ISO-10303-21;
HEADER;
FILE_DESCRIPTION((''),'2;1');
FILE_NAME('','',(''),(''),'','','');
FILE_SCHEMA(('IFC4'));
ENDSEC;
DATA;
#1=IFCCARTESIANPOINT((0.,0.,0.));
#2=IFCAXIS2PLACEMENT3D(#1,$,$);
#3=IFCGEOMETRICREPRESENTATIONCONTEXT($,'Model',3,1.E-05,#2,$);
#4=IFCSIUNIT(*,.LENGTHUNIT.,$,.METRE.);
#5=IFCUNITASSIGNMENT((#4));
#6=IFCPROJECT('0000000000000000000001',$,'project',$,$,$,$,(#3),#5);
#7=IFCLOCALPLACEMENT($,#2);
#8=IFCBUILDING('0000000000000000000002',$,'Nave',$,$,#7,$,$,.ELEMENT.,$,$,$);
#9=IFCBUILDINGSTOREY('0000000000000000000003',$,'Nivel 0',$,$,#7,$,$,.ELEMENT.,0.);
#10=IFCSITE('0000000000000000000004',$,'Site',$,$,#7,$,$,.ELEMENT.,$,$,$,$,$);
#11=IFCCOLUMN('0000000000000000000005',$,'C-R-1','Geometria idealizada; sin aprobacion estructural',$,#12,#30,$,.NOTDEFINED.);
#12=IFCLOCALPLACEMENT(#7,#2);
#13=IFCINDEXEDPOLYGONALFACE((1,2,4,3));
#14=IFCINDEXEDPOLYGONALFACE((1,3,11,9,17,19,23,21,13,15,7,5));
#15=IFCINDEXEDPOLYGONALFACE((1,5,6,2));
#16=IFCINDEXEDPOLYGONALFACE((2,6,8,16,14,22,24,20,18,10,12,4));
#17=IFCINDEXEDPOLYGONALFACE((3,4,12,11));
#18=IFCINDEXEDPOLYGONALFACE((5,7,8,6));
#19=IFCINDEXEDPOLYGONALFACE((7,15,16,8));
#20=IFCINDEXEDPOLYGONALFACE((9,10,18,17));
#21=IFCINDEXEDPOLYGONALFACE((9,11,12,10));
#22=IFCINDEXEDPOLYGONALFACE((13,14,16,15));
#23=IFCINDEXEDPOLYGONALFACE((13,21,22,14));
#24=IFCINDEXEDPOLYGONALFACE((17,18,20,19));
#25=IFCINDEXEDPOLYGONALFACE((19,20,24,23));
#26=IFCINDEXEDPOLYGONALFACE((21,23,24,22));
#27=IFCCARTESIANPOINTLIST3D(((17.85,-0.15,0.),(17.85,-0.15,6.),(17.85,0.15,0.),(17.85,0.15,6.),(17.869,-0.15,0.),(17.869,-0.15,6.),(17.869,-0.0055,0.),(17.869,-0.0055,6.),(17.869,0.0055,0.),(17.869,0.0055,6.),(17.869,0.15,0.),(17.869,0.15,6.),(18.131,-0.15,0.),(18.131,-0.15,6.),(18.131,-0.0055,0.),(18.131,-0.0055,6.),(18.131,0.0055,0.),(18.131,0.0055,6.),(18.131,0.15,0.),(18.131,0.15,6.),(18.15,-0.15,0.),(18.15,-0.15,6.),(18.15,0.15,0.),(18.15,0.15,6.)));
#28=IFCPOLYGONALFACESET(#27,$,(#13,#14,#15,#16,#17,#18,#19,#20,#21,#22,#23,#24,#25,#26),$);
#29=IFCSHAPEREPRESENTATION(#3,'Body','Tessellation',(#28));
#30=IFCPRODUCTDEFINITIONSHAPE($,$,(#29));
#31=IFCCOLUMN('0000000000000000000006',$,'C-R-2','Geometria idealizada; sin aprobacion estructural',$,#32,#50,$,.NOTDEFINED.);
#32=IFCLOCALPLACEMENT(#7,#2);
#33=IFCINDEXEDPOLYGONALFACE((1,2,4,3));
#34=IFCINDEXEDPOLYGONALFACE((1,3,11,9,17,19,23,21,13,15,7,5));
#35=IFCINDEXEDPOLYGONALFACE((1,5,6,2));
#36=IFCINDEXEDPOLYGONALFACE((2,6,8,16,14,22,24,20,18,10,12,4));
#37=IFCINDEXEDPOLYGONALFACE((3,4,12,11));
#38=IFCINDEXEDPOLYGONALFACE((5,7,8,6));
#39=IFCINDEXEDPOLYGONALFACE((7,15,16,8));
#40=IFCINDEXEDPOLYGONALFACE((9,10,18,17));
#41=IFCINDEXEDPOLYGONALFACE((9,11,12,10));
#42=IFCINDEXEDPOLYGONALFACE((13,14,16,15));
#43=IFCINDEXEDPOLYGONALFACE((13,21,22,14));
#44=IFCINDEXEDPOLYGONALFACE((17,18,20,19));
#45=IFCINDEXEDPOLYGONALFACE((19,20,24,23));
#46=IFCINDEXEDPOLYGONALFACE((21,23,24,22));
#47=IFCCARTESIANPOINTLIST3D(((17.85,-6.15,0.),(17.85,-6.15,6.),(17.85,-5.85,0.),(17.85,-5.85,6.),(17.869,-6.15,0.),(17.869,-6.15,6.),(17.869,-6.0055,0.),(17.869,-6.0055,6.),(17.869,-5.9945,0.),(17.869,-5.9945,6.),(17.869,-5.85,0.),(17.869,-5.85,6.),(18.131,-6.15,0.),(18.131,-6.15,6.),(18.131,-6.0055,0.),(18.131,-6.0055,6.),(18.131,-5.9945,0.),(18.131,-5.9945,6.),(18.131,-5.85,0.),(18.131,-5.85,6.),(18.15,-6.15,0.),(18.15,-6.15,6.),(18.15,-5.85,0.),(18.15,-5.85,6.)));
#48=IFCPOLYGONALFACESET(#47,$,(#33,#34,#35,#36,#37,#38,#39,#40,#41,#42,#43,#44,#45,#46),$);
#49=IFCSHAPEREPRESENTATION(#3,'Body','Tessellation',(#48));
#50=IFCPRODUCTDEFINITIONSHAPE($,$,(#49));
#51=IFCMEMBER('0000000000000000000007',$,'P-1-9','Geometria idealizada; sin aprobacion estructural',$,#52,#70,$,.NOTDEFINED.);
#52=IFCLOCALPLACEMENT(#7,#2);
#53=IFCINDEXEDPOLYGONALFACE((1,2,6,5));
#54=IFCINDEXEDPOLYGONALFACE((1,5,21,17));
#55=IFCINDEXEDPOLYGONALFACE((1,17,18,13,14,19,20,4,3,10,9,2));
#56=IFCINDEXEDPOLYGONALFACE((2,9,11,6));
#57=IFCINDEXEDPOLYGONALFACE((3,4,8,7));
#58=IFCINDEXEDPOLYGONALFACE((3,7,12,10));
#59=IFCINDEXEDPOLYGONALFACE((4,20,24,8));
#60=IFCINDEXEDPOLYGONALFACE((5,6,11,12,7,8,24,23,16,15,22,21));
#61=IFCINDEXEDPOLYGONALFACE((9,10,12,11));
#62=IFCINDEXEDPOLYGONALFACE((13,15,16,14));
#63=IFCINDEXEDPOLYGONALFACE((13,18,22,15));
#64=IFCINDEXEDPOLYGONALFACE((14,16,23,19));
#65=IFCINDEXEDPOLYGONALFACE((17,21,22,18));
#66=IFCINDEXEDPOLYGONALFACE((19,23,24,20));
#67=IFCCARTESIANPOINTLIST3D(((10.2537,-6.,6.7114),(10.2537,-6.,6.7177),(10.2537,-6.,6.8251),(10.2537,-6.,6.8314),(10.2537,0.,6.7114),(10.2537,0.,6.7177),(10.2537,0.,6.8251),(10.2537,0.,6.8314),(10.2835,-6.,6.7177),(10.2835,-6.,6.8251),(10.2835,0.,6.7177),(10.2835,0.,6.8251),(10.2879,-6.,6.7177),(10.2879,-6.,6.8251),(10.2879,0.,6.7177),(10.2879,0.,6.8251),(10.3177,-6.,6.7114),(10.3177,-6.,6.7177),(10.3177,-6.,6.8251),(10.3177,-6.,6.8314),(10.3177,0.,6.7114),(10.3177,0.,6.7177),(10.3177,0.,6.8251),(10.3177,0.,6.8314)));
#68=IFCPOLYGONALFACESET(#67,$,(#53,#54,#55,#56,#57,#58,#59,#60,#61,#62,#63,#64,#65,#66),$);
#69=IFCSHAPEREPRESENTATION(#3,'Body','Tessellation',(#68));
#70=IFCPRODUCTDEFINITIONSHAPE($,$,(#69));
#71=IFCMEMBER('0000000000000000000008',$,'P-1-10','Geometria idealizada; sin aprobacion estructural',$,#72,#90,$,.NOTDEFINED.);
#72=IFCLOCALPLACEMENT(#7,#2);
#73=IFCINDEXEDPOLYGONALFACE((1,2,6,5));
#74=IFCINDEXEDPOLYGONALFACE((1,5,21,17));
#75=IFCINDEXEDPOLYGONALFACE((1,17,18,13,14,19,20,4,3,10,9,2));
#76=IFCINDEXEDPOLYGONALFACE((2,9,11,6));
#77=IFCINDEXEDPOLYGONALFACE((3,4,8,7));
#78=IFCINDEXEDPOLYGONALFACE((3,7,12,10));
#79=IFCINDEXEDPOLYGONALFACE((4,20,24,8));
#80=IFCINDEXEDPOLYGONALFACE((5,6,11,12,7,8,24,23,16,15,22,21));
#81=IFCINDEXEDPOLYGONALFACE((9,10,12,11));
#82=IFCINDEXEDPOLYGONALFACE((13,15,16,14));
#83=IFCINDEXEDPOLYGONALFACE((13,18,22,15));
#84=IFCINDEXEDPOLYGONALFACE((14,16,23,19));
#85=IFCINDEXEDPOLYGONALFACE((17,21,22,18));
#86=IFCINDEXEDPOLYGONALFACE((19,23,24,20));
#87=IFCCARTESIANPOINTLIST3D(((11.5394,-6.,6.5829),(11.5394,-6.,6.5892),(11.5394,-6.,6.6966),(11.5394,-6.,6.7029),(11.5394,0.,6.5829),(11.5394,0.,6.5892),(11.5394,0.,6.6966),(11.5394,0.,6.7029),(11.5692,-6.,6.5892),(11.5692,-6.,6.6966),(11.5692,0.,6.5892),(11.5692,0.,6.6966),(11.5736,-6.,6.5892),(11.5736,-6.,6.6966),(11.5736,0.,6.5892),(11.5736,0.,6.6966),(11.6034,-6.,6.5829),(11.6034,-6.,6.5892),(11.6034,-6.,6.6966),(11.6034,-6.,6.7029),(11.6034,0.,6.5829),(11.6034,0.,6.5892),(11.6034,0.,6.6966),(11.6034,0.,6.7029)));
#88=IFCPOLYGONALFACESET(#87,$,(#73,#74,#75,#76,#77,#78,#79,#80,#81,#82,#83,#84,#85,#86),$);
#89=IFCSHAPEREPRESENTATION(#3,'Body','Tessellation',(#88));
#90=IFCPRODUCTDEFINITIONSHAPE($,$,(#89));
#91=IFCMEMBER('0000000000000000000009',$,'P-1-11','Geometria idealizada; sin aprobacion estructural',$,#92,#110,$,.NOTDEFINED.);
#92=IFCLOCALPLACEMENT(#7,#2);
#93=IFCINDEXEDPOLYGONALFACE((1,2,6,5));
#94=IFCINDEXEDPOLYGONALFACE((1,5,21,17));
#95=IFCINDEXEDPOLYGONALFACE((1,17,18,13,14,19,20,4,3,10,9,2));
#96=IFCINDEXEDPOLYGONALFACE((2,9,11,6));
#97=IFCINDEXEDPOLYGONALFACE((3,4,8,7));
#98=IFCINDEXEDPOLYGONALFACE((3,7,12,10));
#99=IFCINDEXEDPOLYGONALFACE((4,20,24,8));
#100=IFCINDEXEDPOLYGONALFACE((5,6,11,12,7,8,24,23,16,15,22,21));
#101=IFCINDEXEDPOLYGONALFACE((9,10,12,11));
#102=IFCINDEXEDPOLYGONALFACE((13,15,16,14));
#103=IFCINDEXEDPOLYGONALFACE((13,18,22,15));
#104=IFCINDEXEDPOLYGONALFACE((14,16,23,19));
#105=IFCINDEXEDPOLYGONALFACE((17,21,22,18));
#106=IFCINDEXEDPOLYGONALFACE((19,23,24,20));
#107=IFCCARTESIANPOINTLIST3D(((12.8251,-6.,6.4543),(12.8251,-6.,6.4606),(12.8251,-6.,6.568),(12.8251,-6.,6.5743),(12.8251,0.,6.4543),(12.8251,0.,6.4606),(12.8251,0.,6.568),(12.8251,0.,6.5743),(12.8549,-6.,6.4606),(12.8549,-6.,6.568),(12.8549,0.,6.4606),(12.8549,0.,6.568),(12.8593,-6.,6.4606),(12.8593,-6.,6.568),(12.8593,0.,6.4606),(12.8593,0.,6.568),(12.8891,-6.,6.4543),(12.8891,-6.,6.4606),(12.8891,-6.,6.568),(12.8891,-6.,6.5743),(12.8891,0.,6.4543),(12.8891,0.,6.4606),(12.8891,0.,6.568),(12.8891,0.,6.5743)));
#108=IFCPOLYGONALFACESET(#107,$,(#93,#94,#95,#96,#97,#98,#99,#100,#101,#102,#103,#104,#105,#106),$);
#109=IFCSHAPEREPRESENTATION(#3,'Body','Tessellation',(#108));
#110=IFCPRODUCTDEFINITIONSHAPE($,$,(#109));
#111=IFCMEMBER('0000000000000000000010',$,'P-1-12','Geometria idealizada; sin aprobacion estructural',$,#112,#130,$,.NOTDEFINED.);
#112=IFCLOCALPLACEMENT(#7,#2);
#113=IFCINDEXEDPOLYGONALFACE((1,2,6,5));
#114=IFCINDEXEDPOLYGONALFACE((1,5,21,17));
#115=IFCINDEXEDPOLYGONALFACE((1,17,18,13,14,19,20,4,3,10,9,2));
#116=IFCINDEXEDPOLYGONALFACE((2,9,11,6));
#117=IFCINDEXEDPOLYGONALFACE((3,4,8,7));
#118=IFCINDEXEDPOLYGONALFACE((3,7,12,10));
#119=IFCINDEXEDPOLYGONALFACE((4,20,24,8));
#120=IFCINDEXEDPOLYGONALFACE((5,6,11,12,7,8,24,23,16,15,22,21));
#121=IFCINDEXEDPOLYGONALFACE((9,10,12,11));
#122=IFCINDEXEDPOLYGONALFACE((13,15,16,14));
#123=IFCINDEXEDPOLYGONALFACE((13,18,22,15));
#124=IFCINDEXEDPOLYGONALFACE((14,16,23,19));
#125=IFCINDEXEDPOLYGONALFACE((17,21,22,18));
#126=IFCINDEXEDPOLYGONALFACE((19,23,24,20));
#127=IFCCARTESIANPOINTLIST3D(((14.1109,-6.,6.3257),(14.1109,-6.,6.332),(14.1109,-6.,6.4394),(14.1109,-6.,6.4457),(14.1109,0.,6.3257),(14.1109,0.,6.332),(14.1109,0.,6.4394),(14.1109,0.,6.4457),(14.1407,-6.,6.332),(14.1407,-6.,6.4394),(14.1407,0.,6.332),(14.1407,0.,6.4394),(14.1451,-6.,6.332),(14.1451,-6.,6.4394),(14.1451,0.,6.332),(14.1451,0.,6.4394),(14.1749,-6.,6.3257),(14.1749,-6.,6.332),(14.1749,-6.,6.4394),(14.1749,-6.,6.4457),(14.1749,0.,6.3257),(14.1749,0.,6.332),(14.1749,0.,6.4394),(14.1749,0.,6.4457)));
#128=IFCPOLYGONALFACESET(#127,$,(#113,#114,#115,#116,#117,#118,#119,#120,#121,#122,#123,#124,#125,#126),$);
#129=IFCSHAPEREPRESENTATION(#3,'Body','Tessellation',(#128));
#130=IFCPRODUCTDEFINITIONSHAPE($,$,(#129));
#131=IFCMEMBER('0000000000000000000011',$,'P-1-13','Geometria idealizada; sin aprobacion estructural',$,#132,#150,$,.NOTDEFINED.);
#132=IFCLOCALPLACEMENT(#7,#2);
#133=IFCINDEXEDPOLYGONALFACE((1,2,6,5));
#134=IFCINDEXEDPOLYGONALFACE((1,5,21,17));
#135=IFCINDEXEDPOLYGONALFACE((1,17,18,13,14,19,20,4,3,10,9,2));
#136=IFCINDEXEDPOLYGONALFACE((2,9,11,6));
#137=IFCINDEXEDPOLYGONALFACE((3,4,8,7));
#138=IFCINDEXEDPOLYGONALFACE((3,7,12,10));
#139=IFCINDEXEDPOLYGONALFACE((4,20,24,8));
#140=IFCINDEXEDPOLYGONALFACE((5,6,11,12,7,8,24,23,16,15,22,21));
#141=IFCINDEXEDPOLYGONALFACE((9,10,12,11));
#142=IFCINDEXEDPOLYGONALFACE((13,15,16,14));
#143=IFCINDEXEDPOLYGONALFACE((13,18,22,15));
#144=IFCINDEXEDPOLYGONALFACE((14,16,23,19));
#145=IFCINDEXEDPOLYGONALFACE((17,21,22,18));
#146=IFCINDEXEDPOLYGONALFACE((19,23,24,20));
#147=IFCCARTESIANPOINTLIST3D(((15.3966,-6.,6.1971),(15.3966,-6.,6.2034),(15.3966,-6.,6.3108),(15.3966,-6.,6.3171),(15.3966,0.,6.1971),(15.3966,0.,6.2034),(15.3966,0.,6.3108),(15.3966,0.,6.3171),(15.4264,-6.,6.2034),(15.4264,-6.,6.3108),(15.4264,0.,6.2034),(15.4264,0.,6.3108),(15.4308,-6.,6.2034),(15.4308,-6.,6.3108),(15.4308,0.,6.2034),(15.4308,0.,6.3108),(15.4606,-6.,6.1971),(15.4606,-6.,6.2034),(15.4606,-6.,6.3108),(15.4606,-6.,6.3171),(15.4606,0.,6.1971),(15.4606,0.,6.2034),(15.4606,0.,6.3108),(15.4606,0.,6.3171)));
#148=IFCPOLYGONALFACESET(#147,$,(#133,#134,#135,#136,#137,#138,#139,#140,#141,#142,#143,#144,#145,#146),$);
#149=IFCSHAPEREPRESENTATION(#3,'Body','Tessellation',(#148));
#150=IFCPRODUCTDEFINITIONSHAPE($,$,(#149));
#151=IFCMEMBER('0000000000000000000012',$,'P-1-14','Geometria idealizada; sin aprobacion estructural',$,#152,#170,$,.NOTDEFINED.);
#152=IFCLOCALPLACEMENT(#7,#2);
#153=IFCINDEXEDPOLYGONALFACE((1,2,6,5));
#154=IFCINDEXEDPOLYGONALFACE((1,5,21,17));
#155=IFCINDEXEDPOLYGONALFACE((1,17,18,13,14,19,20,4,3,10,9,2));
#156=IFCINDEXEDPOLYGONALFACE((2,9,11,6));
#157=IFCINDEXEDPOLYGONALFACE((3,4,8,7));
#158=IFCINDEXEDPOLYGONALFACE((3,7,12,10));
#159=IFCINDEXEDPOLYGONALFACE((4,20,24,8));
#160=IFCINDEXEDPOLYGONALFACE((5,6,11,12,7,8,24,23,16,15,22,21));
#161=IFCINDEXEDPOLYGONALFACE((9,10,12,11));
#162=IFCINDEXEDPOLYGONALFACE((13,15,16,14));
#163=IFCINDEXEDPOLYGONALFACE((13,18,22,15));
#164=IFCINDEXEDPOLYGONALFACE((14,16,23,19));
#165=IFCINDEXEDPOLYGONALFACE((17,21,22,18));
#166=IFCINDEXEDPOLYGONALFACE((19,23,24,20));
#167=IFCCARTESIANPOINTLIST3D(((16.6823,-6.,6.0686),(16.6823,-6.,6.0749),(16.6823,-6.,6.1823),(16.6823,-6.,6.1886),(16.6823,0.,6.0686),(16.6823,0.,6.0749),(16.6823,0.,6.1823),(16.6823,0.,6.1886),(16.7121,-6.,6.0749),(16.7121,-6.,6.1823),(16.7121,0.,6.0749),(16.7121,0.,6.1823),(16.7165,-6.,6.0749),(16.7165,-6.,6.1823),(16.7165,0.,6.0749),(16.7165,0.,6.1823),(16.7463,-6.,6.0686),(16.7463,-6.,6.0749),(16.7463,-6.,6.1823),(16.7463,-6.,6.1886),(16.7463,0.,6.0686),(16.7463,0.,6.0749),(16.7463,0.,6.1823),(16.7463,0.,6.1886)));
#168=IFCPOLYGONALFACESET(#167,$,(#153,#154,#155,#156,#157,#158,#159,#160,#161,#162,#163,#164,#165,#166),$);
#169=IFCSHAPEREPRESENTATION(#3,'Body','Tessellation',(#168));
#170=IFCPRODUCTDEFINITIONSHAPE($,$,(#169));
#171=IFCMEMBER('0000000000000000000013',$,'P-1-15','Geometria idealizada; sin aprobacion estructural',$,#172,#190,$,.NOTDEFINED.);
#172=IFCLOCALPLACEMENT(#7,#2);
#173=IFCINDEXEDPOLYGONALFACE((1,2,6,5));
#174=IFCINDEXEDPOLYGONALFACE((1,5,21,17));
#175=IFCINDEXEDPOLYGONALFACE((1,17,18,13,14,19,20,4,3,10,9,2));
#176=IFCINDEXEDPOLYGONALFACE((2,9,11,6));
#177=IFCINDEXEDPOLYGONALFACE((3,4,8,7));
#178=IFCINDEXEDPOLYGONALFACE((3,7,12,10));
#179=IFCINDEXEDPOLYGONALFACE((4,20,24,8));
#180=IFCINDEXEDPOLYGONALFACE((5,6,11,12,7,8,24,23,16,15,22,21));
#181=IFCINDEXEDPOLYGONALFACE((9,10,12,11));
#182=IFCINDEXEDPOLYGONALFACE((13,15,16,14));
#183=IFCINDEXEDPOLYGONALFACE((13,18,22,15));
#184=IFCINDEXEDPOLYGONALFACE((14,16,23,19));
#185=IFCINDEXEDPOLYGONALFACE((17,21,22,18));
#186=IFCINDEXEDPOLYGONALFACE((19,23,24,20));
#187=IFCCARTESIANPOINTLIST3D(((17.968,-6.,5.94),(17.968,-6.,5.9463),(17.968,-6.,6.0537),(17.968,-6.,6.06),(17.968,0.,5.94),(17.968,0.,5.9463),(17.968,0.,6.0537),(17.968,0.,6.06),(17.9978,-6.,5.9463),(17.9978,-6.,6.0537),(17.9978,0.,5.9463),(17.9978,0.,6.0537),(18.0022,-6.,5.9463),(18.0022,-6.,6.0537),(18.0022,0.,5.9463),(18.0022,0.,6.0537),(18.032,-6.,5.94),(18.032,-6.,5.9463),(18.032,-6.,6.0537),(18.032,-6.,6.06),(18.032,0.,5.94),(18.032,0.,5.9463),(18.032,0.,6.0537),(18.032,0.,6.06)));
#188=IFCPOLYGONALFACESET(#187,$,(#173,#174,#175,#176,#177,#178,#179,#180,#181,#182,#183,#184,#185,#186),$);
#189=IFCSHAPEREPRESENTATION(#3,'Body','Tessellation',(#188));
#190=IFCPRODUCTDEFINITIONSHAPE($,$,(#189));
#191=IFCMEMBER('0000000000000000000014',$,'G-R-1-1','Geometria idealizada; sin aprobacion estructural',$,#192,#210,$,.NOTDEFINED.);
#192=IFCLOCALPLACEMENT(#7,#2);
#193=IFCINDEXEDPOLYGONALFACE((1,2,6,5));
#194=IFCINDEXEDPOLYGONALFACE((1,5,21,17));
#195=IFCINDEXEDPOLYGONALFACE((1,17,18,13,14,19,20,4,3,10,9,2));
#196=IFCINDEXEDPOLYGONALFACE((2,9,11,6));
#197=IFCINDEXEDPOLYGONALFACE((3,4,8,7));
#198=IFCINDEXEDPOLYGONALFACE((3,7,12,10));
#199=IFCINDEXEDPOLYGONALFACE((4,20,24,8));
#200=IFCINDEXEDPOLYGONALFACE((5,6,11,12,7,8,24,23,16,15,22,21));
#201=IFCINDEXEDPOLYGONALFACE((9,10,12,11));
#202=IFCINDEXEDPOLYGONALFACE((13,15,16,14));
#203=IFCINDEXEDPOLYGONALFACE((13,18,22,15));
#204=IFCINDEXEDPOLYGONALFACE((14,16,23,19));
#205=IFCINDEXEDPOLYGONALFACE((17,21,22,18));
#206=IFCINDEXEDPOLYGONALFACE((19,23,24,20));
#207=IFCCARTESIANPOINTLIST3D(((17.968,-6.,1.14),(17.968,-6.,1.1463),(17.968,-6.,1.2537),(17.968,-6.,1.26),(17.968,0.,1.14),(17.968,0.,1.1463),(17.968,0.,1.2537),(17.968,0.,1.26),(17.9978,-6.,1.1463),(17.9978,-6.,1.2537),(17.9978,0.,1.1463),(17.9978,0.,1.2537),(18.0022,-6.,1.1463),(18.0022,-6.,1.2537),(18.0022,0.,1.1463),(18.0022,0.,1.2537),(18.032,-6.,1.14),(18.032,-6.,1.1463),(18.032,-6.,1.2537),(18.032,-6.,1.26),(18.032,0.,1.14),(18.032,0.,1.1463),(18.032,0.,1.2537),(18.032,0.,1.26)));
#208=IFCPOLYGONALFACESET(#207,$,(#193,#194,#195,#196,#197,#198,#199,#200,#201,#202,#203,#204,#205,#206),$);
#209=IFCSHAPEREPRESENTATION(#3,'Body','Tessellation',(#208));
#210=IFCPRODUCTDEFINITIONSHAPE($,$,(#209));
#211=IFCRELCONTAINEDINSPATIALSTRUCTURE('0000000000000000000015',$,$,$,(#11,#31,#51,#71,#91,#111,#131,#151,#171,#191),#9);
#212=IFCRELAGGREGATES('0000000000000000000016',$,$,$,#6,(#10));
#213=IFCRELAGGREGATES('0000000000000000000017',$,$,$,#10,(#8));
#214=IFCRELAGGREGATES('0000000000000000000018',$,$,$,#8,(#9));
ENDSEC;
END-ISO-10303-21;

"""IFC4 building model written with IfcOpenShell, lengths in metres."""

from ifc_helpers import new_model, si_unit, frame, origin, place, context, project, spatial, polyline, outline, extrude, element, save


model = new_model("IFC4")

# Units and contexts
model_context = context("Model", 3, precision=1e-05, world=origin())
ifc_project = project(units=[si_unit("LENGTHUNIT", "METRE")], contexts=[model_context])

# Site, building, storey
placement = place(None, origin())
site = spatial("IfcSite", under=ifc_project, at=placement, Name="Site", CompositionType="ELEMENT")
building = spatial("IfcBuilding", under=site, at=placement, Name="Nave", CompositionType="ELEMENT")
storey = spatial("IfcBuildingStorey", under=building, at=placement, Name="Nivel 0", CompositionType="ELEMENT", Elevation=0.0)

# Columns
for number, where, z_axis, x_axis, name in (
    (1, (18.0, 0.0, 0.0), (0.0, 0.0, 1.0), (0.0, -1.0, 0.0), "C-R-1"),
    (2, (18.0, -6.0, 0.0), (0.0, 0.0, 1.0), (0.0, -1.0, 0.0), "C-R-2"),
):
    element("IfcColumn", number, at=place(placement, frame(where, z_axis=z_axis, x_axis=x_axis)), inside=storey, Name=name, Description="Geometria idealizada; sin aprobacion estructural", PredefinedType="NOTDEFINED", context=model_context, shape_type="SweptSolid", body=[
        extrude(outline(polyline([(-0.15, -0.15), (0.15, -0.15), (0.15, -0.131), (0.0055, -0.131), (0.0055, 0.131), (0.15, 0.131), (0.15, 0.15), (-0.15, 0.15), (-0.15, 0.131), (-0.0055, 0.131), (-0.0055, -0.131), (-0.15, -0.131), (-0.15, -0.15)])), origin(), (0.0, 0.0, 1.0), 6.0),
    ])

# Members
for number, where, z_axis, x_axis, name in (
    (3, (10.2857, 0.0, 6.7714), (0.0, -1.0, 0.0), (1.0, 0.0, 0.0), "P-1-9"),
    (4, (11.5714, 0.0, 6.6429), (0.0, -1.0, 0.0), (1.0, 0.0, 0.0), "P-1-10"),
    (5, (12.8571, 0.0, 6.5143), (0.0, -1.0, 0.0), (1.0, 0.0, 0.0), "P-1-11"),
    (6, (14.1429, 0.0, 6.3857), (0.0, -1.0, 0.0), (1.0, 0.0, 0.0), "P-1-12"),
    (7, (15.4286, 0.0, 6.2571), (0.0, -1.0, 0.0), (1.0, 0.0, 0.0), "P-1-13"),
    (8, (16.7143, 0.0, 6.1286), (0.0, -1.0, 0.0), (1.0, 0.0, 0.0), "P-1-14"),
    (9, (18.0, 0.0, 6.0), (0.0, -1.0, 0.0), (1.0, 0.0, 0.0), "P-1-15"),
    (10, (18.0, 0.0, 1.2), (0.0, -1.0, 0.0), (1.0, 0.0, 0.0), "G-R-1-1"),
):
    element("IfcMember", number, at=place(placement, frame(where, z_axis=z_axis, x_axis=x_axis)), inside=storey, Name=name, Description="Geometria idealizada; sin aprobacion estructural", PredefinedType="NOTDEFINED", context=model_context, shape_type="SweptSolid", body=[
        extrude(outline(polyline([(-0.032, -0.06), (0.032, -0.06), (0.032, -0.0537), (0.0022, -0.0537), (0.0022, 0.0537), (0.032, 0.0537), (0.032, 0.06), (-0.032, 0.06), (-0.032, 0.0537), (-0.0022, 0.0537), (-0.0022, -0.0537), (-0.032, -0.0537), (-0.032, -0.06)])), origin(), (0.0, 0.0, 1.0), 6.0),
    ])

save(model, "model.ifc")
